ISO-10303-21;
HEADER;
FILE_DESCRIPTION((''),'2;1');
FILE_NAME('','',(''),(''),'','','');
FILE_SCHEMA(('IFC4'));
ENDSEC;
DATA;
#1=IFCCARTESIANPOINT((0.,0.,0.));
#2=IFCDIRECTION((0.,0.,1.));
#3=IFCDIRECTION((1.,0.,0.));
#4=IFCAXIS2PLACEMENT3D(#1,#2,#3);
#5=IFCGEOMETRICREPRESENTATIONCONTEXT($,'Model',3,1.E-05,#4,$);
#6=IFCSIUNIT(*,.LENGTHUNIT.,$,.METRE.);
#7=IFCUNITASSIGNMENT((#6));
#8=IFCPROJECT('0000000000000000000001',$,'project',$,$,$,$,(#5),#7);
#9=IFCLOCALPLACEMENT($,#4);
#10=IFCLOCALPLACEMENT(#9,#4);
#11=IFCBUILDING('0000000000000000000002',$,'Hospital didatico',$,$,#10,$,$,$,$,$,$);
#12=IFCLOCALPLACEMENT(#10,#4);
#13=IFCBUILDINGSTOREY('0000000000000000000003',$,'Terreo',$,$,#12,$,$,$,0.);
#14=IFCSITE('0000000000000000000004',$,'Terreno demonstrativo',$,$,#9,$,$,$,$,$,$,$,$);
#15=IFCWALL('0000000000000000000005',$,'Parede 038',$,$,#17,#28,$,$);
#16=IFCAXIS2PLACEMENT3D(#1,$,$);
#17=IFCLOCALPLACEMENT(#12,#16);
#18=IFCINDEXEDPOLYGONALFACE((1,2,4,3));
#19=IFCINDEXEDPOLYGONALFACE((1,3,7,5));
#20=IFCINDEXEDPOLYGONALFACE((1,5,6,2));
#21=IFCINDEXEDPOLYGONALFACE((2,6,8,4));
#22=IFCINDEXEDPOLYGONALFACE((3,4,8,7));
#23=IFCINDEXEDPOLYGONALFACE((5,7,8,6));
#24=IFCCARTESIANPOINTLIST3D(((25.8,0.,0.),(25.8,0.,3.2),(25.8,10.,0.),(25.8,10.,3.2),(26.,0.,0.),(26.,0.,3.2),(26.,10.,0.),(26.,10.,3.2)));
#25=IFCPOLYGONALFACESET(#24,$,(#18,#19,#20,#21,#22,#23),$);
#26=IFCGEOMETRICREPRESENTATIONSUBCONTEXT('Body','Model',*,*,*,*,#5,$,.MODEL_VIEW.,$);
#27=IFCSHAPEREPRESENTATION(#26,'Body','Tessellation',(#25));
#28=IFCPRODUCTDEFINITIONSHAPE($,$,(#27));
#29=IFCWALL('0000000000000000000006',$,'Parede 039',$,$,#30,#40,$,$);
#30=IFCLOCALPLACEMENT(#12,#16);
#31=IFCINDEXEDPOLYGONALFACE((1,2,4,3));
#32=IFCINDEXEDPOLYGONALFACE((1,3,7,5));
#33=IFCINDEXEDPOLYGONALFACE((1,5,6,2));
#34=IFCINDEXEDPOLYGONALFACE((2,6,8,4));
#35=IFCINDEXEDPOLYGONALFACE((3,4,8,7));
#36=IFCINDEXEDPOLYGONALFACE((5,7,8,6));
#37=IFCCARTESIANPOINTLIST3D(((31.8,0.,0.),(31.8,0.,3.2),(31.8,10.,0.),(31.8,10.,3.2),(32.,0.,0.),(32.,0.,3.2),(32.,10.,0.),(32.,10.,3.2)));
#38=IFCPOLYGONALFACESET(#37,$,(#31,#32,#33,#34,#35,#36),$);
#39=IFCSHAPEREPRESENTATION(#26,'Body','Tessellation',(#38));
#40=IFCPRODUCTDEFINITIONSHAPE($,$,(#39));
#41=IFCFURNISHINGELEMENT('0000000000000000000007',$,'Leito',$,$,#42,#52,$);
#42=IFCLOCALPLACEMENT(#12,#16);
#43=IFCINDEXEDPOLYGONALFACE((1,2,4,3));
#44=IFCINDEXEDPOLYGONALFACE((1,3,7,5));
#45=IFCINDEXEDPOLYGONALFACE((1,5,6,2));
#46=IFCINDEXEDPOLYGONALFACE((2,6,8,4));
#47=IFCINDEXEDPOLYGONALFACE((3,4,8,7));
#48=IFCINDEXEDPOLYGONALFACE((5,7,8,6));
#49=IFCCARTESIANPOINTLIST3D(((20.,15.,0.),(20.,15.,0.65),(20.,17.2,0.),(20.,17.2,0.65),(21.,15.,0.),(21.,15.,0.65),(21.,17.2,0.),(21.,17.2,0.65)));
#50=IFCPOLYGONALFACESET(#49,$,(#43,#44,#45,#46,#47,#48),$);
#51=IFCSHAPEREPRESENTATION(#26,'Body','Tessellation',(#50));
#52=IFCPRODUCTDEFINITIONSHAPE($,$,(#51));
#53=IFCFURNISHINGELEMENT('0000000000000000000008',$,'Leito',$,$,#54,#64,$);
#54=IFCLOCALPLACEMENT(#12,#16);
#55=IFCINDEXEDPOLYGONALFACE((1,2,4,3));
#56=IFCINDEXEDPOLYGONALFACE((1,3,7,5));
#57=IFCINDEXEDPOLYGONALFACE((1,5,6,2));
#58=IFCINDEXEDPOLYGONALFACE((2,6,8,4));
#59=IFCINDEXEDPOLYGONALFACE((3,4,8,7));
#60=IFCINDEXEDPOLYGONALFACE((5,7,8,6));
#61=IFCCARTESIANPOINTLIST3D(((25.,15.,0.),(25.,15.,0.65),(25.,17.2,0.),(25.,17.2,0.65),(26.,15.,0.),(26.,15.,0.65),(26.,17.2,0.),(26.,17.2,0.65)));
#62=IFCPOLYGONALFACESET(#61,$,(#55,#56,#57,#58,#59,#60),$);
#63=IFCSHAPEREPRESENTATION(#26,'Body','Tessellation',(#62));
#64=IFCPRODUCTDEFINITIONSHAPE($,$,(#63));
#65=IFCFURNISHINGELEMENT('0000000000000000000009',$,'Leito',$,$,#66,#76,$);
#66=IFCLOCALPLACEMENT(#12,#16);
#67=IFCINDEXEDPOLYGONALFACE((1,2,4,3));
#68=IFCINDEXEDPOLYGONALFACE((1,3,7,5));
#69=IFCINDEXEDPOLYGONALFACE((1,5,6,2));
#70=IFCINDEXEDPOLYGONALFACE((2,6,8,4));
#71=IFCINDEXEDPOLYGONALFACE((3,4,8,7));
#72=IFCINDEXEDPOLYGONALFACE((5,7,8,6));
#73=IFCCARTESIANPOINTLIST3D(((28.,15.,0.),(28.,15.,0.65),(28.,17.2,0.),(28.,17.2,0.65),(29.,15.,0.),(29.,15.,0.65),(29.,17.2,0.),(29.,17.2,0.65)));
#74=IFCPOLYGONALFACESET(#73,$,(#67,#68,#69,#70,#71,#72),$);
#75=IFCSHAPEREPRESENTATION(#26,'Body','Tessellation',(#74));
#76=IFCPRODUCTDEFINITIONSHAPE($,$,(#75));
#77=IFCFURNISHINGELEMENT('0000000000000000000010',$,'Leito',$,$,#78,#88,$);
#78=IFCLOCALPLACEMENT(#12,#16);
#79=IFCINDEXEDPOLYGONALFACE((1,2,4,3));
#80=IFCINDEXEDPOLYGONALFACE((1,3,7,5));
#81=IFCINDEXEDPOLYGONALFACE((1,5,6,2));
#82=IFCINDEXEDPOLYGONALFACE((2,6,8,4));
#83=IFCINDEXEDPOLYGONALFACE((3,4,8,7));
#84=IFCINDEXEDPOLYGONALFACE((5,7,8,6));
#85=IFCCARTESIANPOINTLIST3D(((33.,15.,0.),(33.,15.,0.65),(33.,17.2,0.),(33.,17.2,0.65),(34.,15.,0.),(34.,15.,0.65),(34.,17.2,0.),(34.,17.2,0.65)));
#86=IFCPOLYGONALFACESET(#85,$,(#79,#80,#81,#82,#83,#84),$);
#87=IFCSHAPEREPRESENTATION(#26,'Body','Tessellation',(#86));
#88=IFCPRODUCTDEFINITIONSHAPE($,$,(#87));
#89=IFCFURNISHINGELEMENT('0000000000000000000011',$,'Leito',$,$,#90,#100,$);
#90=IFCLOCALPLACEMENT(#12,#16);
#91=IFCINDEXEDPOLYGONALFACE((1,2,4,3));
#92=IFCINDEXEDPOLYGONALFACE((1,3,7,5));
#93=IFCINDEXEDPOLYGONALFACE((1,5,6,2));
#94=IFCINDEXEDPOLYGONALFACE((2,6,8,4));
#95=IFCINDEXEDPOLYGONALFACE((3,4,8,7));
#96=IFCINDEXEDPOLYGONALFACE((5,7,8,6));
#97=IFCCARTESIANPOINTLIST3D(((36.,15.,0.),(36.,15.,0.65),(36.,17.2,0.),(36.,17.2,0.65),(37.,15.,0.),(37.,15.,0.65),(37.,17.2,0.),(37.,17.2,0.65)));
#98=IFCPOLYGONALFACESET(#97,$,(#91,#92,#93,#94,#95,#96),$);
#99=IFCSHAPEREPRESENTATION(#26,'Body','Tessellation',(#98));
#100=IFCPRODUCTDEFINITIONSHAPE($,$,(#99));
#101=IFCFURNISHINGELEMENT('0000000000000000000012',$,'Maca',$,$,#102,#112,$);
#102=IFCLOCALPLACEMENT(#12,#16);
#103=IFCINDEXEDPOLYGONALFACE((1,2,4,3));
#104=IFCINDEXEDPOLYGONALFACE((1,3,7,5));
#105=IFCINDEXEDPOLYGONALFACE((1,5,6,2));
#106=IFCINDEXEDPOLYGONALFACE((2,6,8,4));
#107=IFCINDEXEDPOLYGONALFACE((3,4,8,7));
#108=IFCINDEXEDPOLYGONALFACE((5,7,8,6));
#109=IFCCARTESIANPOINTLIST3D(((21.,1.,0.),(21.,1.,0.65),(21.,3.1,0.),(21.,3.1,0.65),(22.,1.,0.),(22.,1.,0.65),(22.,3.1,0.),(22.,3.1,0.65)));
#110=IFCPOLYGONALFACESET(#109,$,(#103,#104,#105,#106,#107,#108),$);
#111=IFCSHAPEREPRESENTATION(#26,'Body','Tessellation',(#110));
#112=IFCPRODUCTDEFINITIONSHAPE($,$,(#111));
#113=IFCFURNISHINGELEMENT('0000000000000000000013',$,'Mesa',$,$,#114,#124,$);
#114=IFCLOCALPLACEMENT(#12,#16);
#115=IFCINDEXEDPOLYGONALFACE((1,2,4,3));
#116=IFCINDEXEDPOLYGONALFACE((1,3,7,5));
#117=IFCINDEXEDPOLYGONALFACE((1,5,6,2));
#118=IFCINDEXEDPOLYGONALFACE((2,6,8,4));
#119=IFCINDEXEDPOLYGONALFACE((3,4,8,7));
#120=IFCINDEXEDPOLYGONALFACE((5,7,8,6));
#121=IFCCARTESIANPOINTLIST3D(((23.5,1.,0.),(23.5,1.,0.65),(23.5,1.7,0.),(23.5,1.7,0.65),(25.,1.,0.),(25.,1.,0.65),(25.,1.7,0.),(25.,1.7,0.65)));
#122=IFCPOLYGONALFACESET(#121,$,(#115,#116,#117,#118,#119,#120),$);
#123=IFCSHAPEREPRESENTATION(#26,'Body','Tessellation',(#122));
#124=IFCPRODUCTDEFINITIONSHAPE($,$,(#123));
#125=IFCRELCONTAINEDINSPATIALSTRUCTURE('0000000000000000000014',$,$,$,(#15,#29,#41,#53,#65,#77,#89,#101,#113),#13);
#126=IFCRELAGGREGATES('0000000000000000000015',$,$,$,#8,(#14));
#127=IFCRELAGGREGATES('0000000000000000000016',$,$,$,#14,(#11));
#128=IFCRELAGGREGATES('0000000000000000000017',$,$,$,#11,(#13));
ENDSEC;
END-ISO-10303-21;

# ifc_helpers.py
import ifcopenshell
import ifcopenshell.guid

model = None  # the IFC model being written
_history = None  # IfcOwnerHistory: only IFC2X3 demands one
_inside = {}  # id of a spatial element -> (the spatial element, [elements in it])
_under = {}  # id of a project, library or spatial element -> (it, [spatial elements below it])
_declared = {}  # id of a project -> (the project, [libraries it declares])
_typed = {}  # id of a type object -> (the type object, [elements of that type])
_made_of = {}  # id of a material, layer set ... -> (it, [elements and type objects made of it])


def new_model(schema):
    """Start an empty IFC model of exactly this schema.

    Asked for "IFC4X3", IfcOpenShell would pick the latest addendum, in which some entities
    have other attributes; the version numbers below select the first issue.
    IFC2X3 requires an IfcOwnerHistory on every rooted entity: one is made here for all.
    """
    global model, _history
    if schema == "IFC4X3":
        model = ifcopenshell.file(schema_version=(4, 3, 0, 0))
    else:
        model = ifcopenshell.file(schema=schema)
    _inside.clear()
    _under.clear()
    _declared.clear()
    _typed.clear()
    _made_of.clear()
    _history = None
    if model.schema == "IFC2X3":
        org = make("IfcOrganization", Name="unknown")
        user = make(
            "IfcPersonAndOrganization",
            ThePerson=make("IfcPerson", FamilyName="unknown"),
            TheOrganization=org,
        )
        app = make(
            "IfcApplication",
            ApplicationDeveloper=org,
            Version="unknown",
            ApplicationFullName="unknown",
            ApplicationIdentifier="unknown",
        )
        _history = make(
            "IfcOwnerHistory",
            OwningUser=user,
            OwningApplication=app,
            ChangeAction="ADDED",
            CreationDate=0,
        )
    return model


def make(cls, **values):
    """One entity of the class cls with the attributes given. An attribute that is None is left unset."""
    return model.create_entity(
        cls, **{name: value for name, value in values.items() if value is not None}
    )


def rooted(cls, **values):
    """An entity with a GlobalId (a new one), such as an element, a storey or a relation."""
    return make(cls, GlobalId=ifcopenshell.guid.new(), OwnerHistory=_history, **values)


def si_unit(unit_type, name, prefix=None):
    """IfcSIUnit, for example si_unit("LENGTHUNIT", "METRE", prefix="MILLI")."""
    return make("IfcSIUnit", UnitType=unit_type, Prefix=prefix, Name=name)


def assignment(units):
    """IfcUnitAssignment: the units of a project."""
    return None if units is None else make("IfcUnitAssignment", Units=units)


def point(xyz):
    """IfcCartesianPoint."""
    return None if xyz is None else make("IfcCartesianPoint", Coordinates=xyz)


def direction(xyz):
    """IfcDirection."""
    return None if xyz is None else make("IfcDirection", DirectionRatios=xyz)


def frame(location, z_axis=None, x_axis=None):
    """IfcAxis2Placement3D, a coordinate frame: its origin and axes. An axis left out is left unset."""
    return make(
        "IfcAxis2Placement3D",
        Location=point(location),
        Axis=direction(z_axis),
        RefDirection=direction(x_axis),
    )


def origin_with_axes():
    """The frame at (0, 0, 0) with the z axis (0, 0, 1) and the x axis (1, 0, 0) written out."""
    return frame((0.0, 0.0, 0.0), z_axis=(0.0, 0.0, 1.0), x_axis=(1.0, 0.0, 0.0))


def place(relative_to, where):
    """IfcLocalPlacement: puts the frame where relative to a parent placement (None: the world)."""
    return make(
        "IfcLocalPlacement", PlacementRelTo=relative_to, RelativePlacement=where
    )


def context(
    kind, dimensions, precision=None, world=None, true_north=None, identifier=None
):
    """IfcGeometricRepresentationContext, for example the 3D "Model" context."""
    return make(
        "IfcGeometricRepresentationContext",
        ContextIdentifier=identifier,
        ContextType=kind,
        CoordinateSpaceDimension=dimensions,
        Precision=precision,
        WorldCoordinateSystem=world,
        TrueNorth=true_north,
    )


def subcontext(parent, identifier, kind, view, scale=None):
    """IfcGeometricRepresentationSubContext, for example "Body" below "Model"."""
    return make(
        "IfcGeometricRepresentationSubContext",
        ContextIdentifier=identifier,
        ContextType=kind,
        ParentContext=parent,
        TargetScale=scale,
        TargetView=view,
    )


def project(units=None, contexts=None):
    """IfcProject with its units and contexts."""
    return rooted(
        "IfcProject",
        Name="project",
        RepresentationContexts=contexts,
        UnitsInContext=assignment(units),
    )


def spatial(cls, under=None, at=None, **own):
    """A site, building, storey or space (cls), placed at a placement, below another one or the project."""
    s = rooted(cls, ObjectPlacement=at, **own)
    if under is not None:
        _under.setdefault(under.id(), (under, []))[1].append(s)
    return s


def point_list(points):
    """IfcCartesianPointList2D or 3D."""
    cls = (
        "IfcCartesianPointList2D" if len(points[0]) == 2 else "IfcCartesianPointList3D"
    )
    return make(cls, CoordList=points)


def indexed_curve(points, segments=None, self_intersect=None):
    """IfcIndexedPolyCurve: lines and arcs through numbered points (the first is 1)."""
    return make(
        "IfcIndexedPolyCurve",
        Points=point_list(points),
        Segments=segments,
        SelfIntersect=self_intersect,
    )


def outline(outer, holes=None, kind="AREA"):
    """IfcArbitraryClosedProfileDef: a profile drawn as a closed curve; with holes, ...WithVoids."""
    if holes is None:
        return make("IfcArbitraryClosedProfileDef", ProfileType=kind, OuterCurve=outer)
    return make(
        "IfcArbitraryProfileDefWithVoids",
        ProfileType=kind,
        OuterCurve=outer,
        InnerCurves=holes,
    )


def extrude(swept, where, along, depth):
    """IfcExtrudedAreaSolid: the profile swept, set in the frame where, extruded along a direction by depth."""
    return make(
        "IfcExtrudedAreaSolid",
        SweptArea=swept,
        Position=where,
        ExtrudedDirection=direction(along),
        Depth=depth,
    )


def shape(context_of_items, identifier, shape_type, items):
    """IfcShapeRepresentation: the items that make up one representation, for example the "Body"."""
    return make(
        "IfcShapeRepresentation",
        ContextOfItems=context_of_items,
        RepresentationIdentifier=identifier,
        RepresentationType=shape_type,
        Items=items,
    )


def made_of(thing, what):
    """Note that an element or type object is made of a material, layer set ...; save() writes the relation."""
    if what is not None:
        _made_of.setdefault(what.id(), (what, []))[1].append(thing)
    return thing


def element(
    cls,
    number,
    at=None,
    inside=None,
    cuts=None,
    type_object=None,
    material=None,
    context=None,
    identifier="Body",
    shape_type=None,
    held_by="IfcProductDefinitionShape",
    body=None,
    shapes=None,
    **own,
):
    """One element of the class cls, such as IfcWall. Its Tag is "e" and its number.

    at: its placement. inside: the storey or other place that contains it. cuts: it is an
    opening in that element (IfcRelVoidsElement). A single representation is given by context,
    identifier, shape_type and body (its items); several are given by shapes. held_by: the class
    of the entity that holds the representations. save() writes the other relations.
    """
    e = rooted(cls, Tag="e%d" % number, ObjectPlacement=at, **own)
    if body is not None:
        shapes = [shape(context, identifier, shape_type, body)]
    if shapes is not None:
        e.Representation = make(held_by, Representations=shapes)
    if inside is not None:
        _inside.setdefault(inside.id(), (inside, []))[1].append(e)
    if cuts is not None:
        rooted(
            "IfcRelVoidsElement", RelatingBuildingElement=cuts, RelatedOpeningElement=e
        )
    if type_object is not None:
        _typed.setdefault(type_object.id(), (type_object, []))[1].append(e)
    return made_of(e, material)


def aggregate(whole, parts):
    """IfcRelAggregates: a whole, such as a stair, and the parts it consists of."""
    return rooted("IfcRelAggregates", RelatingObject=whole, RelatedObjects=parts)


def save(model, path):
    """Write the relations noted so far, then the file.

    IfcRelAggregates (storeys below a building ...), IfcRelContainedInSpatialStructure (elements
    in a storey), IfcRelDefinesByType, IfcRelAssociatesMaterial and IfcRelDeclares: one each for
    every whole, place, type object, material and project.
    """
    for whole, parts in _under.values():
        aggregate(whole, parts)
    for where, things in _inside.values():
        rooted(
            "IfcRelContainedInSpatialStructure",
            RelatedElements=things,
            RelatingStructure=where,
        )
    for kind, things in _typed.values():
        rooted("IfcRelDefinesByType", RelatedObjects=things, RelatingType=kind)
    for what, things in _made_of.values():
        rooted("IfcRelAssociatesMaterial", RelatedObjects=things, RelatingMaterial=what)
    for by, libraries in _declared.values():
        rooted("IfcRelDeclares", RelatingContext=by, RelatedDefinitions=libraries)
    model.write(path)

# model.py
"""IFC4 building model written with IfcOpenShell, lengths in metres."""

from ifc_helpers import new_model, si_unit, frame, origin_with_axes, place, context, subcontext, project, spatial, indexed_curve, outline, extrude, element, save


model = new_model("IFC4")

# Units and contexts
model_context = context("Model", 3, precision=1e-05, world=origin_with_axes())
body_context = subcontext(model_context, "Body", "Model", "MODEL_VIEW")
ifc_project = project(units=[si_unit("LENGTHUNIT", "METRE")], contexts=[model_context])

# Site, building, storey
site_placement = place(None, origin_with_axes())
site = spatial("IfcSite", under=ifc_project, at=site_placement, Name="Terreno demonstrativo")
building_placement = place(site_placement, origin_with_axes())
building = spatial("IfcBuilding", under=site, at=building_placement, Name="Hospital didatico")
storey_placement = place(building_placement, origin_with_axes())
storey = spatial("IfcBuildingStorey", under=building, at=storey_placement, Name="Terreo", Elevation=0.0)

# Walls
for number, where, z_axis, x_axis, name in (
    (1, (26.0, 0.0, 0.0), (0.0, 0.0, 1.0), (0.0, 1.0, 0.0), "Parede 038"),
    (2, (32.0, 0.0, 0.0), (0.0, 0.0, 1.0), (0.0, 1.0, 0.0), "Parede 039"),
):
    element("IfcWall", number, at=place(storey_placement, frame(where, z_axis=z_axis, x_axis=x_axis)), inside=storey, Name=name, context=body_context, shape_type="SweptSolid", body=[
        extrude(outline(indexed_curve([(0.0, 0.0), (0.0, 0.2), (10.0, 0.2), (10.0, 0.0), (0.0, 0.0)], self_intersect=False)), origin_with_axes(), (0.0, 0.0, 1.0), 3.2),
    ])

# Furnishing elements
for number, where, z_axis, x_axis, name in (
    (3, (20.0, 15.0, 0.0), (0.0, 0.0, 1.0), (1.0, 0.0, 0.0), "Leito"),
    (4, (25.0, 15.0, 0.0), (0.0, 0.0, 1.0), (1.0, 0.0, 0.0), "Leito"),
    (5, (28.0, 15.0, 0.0), (0.0, 0.0, 1.0), (1.0, 0.0, 0.0), "Leito"),
    (6, (33.0, 15.0, 0.0), (0.0, 0.0, 1.0), (1.0, 0.0, 0.0), "Leito"),
    (7, (36.0, 15.0, 0.0), (0.0, 0.0, 1.0), (1.0, 0.0, 0.0), "Leito"),
):
    element("IfcFurnishingElement", number, at=place(storey_placement, frame(where, z_axis=z_axis, x_axis=x_axis)), inside=storey, Name=name, context=body_context, shape_type="SweptSolid", body=[
        extrude(outline(indexed_curve([(0.0, 0.0), (0.0, 2.2), (1.0, 2.2), (1.0, 0.0), (0.0, 0.0)], self_intersect=False)), origin_with_axes(), (0.0, 0.0, 1.0), 0.65),
    ])
furnishing_1_placement = place(storey_placement, frame((21.0, 1.0, 0.0), z_axis=(0.0, 0.0, 1.0), x_axis=(1.0, 0.0, 0.0)))
element("IfcFurnishingElement", 8, at=furnishing_1_placement, inside=storey, Name="Maca", context=body_context, shape_type="SweptSolid", body=[
    extrude(outline(indexed_curve([(0.0, 0.0), (0.0, 2.1), (1.0, 2.1), (1.0, 0.0), (0.0, 0.0)], self_intersect=False)), origin_with_axes(), (0.0, 0.0, 1.0), 0.65),
])
furnishing_2_placement = place(storey_placement, frame((23.5, 1.0, 0.0), z_axis=(0.0, 0.0, 1.0), x_axis=(1.0, 0.0, 0.0)))
element("IfcFurnishingElement", 9, at=furnishing_2_placement, inside=storey, Name="Mesa", context=body_context, shape_type="SweptSolid", body=[
    extrude(outline(indexed_curve([(0.0, 0.0), (0.0, 0.7), (1.5, 0.7), (1.5, 0.0), (0.0, 0.0)], self_intersect=False)), origin_with_axes(), (0.0, 0.0, 1.0), 0.65),
])

save(model, "model.ifc")
